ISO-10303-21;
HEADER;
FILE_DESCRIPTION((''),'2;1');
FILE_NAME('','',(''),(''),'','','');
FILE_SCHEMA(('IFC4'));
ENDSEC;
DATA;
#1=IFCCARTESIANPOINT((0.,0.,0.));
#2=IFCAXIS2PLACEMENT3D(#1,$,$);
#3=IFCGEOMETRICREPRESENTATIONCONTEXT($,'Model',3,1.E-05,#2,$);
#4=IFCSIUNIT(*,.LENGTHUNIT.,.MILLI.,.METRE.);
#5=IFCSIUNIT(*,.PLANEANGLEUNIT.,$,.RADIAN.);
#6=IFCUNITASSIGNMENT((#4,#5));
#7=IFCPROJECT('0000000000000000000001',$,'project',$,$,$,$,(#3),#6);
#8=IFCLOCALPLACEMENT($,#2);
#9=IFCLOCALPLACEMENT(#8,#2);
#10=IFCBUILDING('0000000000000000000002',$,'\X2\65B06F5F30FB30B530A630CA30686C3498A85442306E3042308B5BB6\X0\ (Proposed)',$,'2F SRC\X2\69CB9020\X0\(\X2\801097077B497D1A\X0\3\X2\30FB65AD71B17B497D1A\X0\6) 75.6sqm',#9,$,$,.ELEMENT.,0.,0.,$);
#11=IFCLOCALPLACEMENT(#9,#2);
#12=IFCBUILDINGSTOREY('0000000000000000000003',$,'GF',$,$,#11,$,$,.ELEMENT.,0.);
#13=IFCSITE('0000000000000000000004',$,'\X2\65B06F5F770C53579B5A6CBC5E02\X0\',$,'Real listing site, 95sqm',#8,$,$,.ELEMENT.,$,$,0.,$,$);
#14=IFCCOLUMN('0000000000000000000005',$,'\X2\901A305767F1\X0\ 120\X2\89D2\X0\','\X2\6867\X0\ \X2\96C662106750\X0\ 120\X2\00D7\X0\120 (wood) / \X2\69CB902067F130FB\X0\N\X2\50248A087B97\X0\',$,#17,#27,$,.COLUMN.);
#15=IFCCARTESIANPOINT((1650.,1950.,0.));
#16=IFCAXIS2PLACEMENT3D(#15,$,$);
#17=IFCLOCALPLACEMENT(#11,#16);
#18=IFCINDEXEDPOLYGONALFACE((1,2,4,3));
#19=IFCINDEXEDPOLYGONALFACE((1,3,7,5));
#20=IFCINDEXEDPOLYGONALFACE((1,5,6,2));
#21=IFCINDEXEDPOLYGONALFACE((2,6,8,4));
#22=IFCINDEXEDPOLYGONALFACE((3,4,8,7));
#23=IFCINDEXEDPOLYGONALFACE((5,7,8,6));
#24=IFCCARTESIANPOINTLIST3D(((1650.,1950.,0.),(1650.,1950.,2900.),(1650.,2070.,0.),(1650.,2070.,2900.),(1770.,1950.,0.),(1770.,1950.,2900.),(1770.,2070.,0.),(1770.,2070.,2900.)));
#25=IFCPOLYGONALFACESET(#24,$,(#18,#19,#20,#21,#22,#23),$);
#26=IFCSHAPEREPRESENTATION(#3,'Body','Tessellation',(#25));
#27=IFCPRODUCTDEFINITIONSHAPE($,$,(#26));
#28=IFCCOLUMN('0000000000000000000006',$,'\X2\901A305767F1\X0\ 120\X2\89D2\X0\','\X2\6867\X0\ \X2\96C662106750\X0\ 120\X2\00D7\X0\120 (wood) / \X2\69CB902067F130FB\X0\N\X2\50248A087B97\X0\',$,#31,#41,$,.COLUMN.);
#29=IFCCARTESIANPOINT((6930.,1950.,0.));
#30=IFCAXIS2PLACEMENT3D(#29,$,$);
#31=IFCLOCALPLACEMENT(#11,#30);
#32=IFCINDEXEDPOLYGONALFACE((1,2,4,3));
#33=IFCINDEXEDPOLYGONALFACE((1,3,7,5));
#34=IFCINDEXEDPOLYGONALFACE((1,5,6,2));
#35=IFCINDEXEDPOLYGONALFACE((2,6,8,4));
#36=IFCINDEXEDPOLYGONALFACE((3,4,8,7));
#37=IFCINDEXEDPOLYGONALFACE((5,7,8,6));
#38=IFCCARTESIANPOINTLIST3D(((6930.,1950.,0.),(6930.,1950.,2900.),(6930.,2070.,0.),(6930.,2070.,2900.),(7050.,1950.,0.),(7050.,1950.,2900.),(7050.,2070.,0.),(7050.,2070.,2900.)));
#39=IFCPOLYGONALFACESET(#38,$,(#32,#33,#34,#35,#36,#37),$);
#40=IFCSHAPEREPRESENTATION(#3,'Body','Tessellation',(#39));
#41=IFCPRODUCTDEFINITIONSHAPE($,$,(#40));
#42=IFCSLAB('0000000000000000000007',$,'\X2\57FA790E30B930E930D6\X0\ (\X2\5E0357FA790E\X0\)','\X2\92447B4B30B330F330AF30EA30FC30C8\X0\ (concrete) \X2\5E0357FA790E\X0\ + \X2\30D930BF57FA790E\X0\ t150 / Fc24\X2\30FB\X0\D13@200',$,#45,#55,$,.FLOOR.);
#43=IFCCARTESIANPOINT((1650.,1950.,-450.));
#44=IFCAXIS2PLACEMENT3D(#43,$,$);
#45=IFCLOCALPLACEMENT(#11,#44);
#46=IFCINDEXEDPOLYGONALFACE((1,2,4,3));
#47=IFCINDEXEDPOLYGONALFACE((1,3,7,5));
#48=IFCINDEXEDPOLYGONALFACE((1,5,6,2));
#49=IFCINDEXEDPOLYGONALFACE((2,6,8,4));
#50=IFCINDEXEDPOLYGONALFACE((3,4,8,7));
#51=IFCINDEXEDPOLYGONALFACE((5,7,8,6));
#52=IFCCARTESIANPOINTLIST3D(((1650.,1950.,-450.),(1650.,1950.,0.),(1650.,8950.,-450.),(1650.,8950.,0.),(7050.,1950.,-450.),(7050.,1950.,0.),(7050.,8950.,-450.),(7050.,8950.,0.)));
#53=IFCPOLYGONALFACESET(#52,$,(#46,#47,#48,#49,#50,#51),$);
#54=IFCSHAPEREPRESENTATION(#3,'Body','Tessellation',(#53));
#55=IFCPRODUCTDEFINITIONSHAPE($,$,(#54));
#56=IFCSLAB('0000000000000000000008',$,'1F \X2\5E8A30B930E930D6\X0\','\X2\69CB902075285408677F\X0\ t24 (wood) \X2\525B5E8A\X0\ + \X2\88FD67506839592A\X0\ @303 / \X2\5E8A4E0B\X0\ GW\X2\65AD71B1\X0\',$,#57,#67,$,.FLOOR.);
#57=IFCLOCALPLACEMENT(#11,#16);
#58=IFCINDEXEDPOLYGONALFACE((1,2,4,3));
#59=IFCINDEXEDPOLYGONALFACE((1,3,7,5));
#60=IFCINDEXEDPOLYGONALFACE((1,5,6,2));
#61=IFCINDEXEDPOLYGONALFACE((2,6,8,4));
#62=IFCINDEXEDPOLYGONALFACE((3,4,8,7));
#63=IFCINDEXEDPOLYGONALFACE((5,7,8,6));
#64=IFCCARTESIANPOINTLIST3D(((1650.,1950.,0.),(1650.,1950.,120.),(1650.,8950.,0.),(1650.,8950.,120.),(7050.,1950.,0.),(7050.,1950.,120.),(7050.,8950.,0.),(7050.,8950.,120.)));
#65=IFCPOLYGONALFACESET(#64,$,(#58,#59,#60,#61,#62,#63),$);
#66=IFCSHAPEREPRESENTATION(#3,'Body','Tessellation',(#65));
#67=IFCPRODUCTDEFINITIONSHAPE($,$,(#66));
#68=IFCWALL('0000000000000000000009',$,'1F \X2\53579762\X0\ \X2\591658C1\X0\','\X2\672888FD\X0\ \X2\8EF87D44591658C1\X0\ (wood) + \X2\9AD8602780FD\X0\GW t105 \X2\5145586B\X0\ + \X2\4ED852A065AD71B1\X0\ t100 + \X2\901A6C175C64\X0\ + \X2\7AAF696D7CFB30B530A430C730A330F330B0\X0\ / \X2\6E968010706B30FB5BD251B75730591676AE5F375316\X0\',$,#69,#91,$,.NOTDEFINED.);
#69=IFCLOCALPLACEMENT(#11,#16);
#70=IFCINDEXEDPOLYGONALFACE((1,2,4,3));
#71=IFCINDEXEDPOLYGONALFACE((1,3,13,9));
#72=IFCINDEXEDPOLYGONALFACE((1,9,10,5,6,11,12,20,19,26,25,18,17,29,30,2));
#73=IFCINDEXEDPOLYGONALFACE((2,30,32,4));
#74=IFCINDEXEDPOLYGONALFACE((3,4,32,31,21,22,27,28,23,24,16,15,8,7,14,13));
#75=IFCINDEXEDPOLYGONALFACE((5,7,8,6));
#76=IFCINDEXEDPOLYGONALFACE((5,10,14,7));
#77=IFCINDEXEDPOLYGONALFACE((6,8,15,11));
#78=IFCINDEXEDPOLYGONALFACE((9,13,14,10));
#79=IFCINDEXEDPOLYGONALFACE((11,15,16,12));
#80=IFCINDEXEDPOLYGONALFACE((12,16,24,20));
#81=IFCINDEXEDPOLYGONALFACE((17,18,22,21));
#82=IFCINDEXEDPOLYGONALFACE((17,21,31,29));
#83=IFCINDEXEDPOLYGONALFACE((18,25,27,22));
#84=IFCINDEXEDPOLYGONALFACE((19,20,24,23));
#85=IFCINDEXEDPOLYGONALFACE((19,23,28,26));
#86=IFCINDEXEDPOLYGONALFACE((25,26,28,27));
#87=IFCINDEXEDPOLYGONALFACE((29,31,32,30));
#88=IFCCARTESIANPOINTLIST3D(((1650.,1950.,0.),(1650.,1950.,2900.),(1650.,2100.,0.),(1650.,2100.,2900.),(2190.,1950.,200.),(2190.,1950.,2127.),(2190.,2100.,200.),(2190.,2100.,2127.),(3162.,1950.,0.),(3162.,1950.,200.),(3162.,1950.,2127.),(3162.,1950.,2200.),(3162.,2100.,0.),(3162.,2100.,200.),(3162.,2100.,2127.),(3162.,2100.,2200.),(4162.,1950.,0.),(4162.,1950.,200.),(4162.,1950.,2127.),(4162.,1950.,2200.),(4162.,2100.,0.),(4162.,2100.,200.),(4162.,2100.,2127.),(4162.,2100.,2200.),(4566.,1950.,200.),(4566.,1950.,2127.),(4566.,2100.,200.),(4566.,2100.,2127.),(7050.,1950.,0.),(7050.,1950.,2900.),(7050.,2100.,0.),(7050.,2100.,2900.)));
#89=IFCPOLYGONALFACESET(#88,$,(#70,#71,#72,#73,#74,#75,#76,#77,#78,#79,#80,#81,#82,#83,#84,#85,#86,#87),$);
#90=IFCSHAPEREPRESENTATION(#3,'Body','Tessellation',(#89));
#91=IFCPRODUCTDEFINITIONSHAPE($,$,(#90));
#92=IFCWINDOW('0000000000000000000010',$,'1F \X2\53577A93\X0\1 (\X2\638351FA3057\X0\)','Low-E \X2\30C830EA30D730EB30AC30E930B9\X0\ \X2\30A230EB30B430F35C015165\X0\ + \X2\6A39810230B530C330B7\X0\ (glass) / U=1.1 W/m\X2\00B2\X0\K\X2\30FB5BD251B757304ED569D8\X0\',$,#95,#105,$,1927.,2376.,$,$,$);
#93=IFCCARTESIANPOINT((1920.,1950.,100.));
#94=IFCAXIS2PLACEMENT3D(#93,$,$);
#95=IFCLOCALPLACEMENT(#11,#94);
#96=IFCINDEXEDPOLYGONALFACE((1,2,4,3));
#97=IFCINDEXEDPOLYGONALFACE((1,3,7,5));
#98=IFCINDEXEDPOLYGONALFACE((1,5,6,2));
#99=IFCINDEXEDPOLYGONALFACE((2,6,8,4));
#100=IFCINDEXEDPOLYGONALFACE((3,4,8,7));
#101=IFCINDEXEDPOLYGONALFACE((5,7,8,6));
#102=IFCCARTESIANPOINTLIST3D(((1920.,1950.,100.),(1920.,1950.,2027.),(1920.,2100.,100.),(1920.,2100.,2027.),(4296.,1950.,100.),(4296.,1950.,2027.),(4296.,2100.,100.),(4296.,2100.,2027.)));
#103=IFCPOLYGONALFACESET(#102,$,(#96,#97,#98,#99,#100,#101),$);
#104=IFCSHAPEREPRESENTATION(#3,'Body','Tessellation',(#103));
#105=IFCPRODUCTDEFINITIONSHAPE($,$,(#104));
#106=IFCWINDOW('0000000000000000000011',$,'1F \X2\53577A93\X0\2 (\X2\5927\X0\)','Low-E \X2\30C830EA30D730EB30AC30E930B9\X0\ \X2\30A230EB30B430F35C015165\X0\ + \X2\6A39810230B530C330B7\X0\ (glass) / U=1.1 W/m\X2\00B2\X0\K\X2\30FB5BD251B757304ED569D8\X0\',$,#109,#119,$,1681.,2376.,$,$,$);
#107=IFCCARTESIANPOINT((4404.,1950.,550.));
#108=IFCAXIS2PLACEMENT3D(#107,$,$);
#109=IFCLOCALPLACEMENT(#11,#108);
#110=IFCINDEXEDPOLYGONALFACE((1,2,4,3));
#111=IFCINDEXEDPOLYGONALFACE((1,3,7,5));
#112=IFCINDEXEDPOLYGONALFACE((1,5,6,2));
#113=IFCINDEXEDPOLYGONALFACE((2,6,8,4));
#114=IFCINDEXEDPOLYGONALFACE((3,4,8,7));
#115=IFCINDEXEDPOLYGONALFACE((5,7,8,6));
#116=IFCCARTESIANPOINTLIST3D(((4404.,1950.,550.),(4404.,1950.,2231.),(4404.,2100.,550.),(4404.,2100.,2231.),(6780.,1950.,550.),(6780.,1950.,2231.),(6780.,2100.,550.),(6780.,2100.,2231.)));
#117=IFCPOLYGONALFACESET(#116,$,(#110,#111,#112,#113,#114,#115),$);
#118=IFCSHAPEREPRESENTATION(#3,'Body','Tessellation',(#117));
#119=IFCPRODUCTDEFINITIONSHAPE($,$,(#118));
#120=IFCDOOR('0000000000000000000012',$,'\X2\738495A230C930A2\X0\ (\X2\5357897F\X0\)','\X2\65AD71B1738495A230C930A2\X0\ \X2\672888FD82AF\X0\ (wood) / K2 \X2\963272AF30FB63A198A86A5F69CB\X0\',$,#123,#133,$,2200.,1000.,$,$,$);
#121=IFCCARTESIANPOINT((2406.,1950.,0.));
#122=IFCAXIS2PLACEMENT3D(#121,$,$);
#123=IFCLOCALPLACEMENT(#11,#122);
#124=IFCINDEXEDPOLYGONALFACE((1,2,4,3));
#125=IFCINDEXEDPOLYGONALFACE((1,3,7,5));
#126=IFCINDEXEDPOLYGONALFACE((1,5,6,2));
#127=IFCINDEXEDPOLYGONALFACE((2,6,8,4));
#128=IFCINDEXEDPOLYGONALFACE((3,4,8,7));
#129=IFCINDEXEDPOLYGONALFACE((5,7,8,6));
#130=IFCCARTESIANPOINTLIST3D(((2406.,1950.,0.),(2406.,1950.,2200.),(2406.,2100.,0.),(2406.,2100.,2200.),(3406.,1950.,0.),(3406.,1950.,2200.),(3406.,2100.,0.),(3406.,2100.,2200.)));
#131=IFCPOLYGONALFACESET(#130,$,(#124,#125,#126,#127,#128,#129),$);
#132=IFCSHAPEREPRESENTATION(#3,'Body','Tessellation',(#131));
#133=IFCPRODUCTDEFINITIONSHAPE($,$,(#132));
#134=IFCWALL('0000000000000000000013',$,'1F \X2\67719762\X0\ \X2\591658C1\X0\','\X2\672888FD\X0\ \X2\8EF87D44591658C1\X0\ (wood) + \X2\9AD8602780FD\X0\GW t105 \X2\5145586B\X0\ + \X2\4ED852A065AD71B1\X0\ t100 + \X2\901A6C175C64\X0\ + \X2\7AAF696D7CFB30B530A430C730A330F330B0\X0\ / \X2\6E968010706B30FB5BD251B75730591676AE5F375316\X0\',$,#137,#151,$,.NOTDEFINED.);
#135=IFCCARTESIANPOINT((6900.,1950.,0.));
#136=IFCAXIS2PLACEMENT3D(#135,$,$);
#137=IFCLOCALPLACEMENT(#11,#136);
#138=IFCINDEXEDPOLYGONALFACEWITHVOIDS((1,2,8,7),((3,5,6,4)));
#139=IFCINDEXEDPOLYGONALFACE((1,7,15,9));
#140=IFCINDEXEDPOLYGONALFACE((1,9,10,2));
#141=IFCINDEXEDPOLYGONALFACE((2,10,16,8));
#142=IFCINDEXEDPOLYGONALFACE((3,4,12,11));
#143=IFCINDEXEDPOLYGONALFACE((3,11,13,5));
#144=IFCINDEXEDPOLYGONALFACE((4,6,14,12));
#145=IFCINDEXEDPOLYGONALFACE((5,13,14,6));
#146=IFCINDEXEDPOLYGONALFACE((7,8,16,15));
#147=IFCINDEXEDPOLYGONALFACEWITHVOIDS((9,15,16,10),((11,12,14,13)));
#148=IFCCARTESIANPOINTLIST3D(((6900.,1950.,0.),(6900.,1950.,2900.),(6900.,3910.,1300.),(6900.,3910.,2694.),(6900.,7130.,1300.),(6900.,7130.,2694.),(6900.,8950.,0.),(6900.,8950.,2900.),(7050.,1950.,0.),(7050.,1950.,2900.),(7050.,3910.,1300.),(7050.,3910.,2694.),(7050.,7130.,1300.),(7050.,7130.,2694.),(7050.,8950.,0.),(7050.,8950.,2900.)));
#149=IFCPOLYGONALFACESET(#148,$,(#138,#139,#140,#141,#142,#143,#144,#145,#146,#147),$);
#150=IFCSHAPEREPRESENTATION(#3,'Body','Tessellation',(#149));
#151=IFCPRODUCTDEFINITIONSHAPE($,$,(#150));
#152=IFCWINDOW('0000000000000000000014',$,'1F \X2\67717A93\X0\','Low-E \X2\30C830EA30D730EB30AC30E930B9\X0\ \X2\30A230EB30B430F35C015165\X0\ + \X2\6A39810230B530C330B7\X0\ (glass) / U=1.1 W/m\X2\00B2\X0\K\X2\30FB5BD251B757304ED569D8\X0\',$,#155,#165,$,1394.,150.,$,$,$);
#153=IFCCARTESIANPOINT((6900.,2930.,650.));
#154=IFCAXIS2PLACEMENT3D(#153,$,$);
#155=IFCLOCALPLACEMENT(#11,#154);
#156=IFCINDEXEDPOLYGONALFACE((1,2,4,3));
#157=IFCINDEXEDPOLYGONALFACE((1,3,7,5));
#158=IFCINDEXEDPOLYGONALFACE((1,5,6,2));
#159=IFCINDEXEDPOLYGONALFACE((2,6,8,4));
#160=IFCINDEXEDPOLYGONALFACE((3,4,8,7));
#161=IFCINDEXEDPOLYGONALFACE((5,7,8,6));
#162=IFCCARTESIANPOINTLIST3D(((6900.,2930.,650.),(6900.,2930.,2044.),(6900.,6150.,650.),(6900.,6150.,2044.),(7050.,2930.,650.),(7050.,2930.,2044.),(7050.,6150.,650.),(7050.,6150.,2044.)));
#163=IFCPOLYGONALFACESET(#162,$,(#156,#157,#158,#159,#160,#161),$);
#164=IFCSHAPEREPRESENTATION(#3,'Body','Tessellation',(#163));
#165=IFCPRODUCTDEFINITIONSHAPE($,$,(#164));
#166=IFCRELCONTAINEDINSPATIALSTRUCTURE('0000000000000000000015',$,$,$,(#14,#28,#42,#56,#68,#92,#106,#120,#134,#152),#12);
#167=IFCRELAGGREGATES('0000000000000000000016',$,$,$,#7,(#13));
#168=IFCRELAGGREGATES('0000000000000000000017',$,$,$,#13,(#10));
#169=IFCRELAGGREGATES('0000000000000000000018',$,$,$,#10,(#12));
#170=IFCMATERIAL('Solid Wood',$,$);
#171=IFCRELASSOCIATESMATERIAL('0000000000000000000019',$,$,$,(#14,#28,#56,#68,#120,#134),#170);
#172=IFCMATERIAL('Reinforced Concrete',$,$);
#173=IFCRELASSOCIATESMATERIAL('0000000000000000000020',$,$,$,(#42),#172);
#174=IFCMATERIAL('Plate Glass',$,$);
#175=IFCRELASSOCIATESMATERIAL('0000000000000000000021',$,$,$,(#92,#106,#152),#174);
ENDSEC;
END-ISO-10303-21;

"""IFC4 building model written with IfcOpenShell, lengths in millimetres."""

from ifc_helpers import new_model, si_unit, frame, frame_2d, origin, place, context, project, spatial, rectangle, extrude, material, element, fill, save


model = new_model("IFC4")

# Units and contexts
model_context = context("Model", 3, precision=1e-05, world=origin())
ifc_project = project(units=[si_unit("LENGTHUNIT", "METRE", prefix="MILLI"), si_unit("PLANEANGLEUNIT", "RADIAN")], contexts=[model_context])

# Site, building, storey
site_placement = place(None, origin())
site = spatial("IfcSite", under=ifc_project, at=site_placement, Name="新潟県南魚沼市", ObjectType="Real listing site, 95sqm", CompositionType="ELEMENT", RefElevation=0.0)
building_placement = place(site_placement, origin())
building = spatial("IfcBuilding", under=site, at=building_placement, Name="新潟・サウナと水風呂のある家 (Proposed)", ObjectType="2F SRC構造(耐震等級3・断熱等級6) 75.6sqm", CompositionType="ELEMENT", ElevationOfRefHeight=0.0, ElevationOfTerrain=0.0)
storey_placement = place(building_placement, origin())
storey = spatial("IfcBuildingStorey", under=building, at=storey_placement, Name="GF", CompositionType="ELEMENT", Elevation=0.0)

# Columns
ifc_material_1 = material(Name="Solid Wood")
column_1_placement = place(storey_placement, frame((1650.0, 1950.0, 0.0)))
element("IfcColumn", 1, at=column_1_placement, inside=storey, material=ifc_material_1, Name="通し柱 120角", Description="桧 集成材 120×120 (wood) / 構造柱・N値計算", PredefinedType="COLUMN", context=model_context, shape_type="SweptSolid", body=[
    extrude(rectangle(XDim=120.0, YDim=120.0, at=frame_2d((60.0, 60.0))), frame((1650.0, 1950.0, 0.0)), (0.0, 0.0, 1.0), 2900.0),
])
column_2_placement = place(storey_placement, frame((6930.0, 1950.0, 0.0)))
element("IfcColumn", 2, at=column_2_placement, inside=storey, material=ifc_material_1, Name="通し柱 120角", Description="桧 集成材 120×120 (wood) / 構造柱・N値計算", PredefinedType="COLUMN", context=model_context, shape_type="SweptSolid", body=[
    extrude(rectangle(XDim=120.0, YDim=120.0, at=frame_2d((60.0, 60.0))), frame((6930.0, 1950.0, 0.0)), (0.0, 0.0, 1.0), 2900.0),
])

# Slabs
ifc_material_2 = material(Name="Reinforced Concrete")
slab_1_placement = place(storey_placement, frame((1650.0, 1950.0, -450.0)))
element("IfcSlab", 3, at=slab_1_placement, inside=storey, material=ifc_material_2, Name="基礎スラブ (布基礎)", Description="鉄筋コンクリート (concrete) 布基礎 + ベタ基礎 t150 / Fc24・D13@200", PredefinedType="FLOOR", context=model_context, shape_type="SweptSolid", body=[
    extrude(rectangle(XDim=5400.0, YDim=7000.0, at=frame_2d((2700.0, 3500.0))), frame((1650.0, 1950.0, -450.0)), (0.0, 0.0, 1.0), 450.0),
])
slab_2_placement = place(storey_placement, frame((1650.0, 1950.0, 0.0)))
element("IfcSlab", 4, at=slab_2_placement, inside=storey, material=ifc_material_1, Name="1F 床スラブ", Description="構造用合板 t24 (wood) 剛床 + 製材根太 @303 / 床下 GW断熱", PredefinedType="FLOOR", context=model_context, shape_type="SweptSolid", body=[
    extrude(rectangle(XDim=5400.0, YDim=7000.0, at=frame_2d((2700.0, 3500.0))), frame((1650.0, 1950.0, 0.0)), (0.0, 0.0, 1.0), 120.0),
])

# Wall, openings, windows, door
wall_1_placement = place(storey_placement, frame((1650.0, 1950.0, 0.0)))
wall_1 = element("IfcWall", 5, at=wall_1_placement, inside=storey, material=ifc_material_1, Name="1F 南面 外壁", Description="木製 軸組外壁 (wood) + 高性能GW t105 充填 + 付加断熱 t100 + 通気層 + 窯業系サイディング / 準耐火・寒冷地外皮強化", PredefinedType="NOTDEFINED", context=model_context, shape_type="SweptSolid", body=[
    extrude(rectangle(XDim=5400.0, YDim=150.0, at=frame_2d((2700.0, 75.0))), frame((1650.0, 1950.0, 0.0)), (0.0, 0.0, 1.0), 2900.0),
])
opening_1_placement = place(storey_placement, frame((1920.0, 1950.0, 100.0)))
opening_1 = element("IfcOpeningElement", 6, at=opening_1_placement, cuts=wall_1, PredefinedType="NOTDEFINED", context=model_context, shape_type="SweptSolid", body=[
    extrude(rectangle(XDim=2376.0, YDim=150.0, at=frame_2d((1188.0, 75.0))), frame((1920.0, 1950.0, 100.0)), (0.0, 0.0, 1.0), 1927.0),
])
opening_2_placement = place(storey_placement, frame((4404.0, 1950.0, 550.0)))
opening_2 = element("IfcOpeningElement", 7, at=opening_2_placement, cuts=wall_1, PredefinedType="NOTDEFINED", context=model_context, shape_type="SweptSolid", body=[
    extrude(rectangle(XDim=2376.0, YDim=150.0, at=frame_2d((1188.0, 75.0))), frame((4404.0, 1950.0, 550.0)), (0.0, 0.0, 1.0), 1681.0),
])
opening_3_placement = place(storey_placement, frame((2406.0, 1950.0, 0.0)))
opening_3 = element("IfcOpeningElement", 8, at=opening_3_placement, cuts=wall_1, PredefinedType="NOTDEFINED", context=model_context, shape_type="SweptSolid", body=[
    extrude(rectangle(XDim=1000.0, YDim=150.0, at=frame_2d((500.0, 75.0))), frame((2406.0, 1950.0, 0.0)), (0.0, 0.0, 1.0), 2200.0),
])
ifc_material_3 = material(Name="Plate Glass")
window_1_placement = place(storey_placement, frame((1920.0, 1950.0, 100.0)))
window_1 = element("IfcWindow", 9, at=window_1_placement, inside=storey, material=ifc_material_3, Name="1F 南窓1 (掃出し)", Description="Low-E トリプルガラス アルゴン封入 + 樹脂サッシ (glass) / U=1.1 W/m²K・寒冷地仕様", OverallHeight=1927.0, OverallWidth=2376.0, context=model_context, shape_type="SweptSolid", body=[
    extrude(rectangle(XDim=2376.0, YDim=150.0, at=frame_2d((1188.0, 75.0))), frame((1920.0, 1950.0, 100.0)), (0.0, 0.0, 1.0), 1927.0),
])
fill(opening_1, window_1)
window_2_placement = place(storey_placement, frame((4404.0, 1950.0, 550.0)))
window_2 = element("IfcWindow", 10, at=window_2_placement, inside=storey, material=ifc_material_3, Name="1F 南窓2 (大)", Description="Low-E トリプルガラス アルゴン封入 + 樹脂サッシ (glass) / U=1.1 W/m²K・寒冷地仕様", OverallHeight=1681.0, OverallWidth=2376.0, context=model_context, shape_type="SweptSolid", body=[
    extrude(rectangle(XDim=2376.0, YDim=150.0, at=frame_2d((1188.0, 75.0))), frame((4404.0, 1950.0, 550.0)), (0.0, 0.0, 1.0), 1681.0),
])
fill(opening_2, window_2)
door_placement = place(storey_placement, frame((2406.0, 1950.0, 0.0)))
door = element("IfcDoor", 11, at=door_placement, inside=storey, material=ifc_material_1, Name="玄関ドア (南西)", Description="断熱玄関ドア 木製芯 (wood) / K2 防犯・採風機構", OverallHeight=2200.0, OverallWidth=1000.0, context=model_context, shape_type="SweptSolid", body=[
    extrude(rectangle(XDim=1000.0, YDim=150.0, at=frame_2d((500.0, 75.0))), frame((2406.0, 1950.0, 0.0)), (0.0, 0.0, 1.0), 2200.0),
])
fill(opening_3, door)

# Wall, opening, window
wall_2_placement = place(storey_placement, frame((6900.0, 1950.0, 0.0)))
wall_2 = element("IfcWall", 12, at=wall_2_placement, inside=storey, material=ifc_material_1, Name="1F 東面 外壁", Description="木製 軸組外壁 (wood) + 高性能GW t105 充填 + 付加断熱 t100 + 通気層 + 窯業系サイディング / 準耐火・寒冷地外皮強化", PredefinedType="NOTDEFINED", context=model_context, shape_type="SweptSolid", body=[
    extrude(rectangle(XDim=150.0, YDim=7000.0, at=frame_2d((75.0, 3500.0))), frame((6900.0, 1950.0, 0.0)), (0.0, 0.0, 1.0), 2900.0),
])
opening_4_placement = place(storey_placement, frame((6900.0, 2930.0, 650.0)))
opening_4 = element("IfcOpeningElement", 13, at=opening_4_placement, cuts=wall_2, PredefinedType="NOTDEFINED", context=model_context, shape_type="SweptSolid", body=[
    extrude(rectangle(XDim=150.0, YDim=3220.0, at=frame_2d((75.0, 1610.0))), frame((6900.0, 2930.0, 650.0)), (0.0, 0.0, 1.0), 1394.0),
])
window_3_placement = place(storey_placement, frame((6900.0, 2930.0, 650.0)))
window_3 = element("IfcWindow", 14, at=window_3_placement, inside=storey, material=ifc_material_3, Name="1F 東窓", Description="Low-E トリプルガラス アルゴン封入 + 樹脂サッシ (glass) / U=1.1 W/m²K・寒冷地仕様", OverallHeight=1394.0, OverallWidth=150.0, context=model_context, shape_type="SweptSolid", body=[
    extrude(rectangle(XDim=150.0, YDim=3220.0, at=frame_2d((75.0, 1610.0))), frame((6900.0, 2930.0, 650.0)), (0.0, 0.0, 1.0), 1394.0),
])
fill(opening_4, window_3)

save(model, "model.ifc")
